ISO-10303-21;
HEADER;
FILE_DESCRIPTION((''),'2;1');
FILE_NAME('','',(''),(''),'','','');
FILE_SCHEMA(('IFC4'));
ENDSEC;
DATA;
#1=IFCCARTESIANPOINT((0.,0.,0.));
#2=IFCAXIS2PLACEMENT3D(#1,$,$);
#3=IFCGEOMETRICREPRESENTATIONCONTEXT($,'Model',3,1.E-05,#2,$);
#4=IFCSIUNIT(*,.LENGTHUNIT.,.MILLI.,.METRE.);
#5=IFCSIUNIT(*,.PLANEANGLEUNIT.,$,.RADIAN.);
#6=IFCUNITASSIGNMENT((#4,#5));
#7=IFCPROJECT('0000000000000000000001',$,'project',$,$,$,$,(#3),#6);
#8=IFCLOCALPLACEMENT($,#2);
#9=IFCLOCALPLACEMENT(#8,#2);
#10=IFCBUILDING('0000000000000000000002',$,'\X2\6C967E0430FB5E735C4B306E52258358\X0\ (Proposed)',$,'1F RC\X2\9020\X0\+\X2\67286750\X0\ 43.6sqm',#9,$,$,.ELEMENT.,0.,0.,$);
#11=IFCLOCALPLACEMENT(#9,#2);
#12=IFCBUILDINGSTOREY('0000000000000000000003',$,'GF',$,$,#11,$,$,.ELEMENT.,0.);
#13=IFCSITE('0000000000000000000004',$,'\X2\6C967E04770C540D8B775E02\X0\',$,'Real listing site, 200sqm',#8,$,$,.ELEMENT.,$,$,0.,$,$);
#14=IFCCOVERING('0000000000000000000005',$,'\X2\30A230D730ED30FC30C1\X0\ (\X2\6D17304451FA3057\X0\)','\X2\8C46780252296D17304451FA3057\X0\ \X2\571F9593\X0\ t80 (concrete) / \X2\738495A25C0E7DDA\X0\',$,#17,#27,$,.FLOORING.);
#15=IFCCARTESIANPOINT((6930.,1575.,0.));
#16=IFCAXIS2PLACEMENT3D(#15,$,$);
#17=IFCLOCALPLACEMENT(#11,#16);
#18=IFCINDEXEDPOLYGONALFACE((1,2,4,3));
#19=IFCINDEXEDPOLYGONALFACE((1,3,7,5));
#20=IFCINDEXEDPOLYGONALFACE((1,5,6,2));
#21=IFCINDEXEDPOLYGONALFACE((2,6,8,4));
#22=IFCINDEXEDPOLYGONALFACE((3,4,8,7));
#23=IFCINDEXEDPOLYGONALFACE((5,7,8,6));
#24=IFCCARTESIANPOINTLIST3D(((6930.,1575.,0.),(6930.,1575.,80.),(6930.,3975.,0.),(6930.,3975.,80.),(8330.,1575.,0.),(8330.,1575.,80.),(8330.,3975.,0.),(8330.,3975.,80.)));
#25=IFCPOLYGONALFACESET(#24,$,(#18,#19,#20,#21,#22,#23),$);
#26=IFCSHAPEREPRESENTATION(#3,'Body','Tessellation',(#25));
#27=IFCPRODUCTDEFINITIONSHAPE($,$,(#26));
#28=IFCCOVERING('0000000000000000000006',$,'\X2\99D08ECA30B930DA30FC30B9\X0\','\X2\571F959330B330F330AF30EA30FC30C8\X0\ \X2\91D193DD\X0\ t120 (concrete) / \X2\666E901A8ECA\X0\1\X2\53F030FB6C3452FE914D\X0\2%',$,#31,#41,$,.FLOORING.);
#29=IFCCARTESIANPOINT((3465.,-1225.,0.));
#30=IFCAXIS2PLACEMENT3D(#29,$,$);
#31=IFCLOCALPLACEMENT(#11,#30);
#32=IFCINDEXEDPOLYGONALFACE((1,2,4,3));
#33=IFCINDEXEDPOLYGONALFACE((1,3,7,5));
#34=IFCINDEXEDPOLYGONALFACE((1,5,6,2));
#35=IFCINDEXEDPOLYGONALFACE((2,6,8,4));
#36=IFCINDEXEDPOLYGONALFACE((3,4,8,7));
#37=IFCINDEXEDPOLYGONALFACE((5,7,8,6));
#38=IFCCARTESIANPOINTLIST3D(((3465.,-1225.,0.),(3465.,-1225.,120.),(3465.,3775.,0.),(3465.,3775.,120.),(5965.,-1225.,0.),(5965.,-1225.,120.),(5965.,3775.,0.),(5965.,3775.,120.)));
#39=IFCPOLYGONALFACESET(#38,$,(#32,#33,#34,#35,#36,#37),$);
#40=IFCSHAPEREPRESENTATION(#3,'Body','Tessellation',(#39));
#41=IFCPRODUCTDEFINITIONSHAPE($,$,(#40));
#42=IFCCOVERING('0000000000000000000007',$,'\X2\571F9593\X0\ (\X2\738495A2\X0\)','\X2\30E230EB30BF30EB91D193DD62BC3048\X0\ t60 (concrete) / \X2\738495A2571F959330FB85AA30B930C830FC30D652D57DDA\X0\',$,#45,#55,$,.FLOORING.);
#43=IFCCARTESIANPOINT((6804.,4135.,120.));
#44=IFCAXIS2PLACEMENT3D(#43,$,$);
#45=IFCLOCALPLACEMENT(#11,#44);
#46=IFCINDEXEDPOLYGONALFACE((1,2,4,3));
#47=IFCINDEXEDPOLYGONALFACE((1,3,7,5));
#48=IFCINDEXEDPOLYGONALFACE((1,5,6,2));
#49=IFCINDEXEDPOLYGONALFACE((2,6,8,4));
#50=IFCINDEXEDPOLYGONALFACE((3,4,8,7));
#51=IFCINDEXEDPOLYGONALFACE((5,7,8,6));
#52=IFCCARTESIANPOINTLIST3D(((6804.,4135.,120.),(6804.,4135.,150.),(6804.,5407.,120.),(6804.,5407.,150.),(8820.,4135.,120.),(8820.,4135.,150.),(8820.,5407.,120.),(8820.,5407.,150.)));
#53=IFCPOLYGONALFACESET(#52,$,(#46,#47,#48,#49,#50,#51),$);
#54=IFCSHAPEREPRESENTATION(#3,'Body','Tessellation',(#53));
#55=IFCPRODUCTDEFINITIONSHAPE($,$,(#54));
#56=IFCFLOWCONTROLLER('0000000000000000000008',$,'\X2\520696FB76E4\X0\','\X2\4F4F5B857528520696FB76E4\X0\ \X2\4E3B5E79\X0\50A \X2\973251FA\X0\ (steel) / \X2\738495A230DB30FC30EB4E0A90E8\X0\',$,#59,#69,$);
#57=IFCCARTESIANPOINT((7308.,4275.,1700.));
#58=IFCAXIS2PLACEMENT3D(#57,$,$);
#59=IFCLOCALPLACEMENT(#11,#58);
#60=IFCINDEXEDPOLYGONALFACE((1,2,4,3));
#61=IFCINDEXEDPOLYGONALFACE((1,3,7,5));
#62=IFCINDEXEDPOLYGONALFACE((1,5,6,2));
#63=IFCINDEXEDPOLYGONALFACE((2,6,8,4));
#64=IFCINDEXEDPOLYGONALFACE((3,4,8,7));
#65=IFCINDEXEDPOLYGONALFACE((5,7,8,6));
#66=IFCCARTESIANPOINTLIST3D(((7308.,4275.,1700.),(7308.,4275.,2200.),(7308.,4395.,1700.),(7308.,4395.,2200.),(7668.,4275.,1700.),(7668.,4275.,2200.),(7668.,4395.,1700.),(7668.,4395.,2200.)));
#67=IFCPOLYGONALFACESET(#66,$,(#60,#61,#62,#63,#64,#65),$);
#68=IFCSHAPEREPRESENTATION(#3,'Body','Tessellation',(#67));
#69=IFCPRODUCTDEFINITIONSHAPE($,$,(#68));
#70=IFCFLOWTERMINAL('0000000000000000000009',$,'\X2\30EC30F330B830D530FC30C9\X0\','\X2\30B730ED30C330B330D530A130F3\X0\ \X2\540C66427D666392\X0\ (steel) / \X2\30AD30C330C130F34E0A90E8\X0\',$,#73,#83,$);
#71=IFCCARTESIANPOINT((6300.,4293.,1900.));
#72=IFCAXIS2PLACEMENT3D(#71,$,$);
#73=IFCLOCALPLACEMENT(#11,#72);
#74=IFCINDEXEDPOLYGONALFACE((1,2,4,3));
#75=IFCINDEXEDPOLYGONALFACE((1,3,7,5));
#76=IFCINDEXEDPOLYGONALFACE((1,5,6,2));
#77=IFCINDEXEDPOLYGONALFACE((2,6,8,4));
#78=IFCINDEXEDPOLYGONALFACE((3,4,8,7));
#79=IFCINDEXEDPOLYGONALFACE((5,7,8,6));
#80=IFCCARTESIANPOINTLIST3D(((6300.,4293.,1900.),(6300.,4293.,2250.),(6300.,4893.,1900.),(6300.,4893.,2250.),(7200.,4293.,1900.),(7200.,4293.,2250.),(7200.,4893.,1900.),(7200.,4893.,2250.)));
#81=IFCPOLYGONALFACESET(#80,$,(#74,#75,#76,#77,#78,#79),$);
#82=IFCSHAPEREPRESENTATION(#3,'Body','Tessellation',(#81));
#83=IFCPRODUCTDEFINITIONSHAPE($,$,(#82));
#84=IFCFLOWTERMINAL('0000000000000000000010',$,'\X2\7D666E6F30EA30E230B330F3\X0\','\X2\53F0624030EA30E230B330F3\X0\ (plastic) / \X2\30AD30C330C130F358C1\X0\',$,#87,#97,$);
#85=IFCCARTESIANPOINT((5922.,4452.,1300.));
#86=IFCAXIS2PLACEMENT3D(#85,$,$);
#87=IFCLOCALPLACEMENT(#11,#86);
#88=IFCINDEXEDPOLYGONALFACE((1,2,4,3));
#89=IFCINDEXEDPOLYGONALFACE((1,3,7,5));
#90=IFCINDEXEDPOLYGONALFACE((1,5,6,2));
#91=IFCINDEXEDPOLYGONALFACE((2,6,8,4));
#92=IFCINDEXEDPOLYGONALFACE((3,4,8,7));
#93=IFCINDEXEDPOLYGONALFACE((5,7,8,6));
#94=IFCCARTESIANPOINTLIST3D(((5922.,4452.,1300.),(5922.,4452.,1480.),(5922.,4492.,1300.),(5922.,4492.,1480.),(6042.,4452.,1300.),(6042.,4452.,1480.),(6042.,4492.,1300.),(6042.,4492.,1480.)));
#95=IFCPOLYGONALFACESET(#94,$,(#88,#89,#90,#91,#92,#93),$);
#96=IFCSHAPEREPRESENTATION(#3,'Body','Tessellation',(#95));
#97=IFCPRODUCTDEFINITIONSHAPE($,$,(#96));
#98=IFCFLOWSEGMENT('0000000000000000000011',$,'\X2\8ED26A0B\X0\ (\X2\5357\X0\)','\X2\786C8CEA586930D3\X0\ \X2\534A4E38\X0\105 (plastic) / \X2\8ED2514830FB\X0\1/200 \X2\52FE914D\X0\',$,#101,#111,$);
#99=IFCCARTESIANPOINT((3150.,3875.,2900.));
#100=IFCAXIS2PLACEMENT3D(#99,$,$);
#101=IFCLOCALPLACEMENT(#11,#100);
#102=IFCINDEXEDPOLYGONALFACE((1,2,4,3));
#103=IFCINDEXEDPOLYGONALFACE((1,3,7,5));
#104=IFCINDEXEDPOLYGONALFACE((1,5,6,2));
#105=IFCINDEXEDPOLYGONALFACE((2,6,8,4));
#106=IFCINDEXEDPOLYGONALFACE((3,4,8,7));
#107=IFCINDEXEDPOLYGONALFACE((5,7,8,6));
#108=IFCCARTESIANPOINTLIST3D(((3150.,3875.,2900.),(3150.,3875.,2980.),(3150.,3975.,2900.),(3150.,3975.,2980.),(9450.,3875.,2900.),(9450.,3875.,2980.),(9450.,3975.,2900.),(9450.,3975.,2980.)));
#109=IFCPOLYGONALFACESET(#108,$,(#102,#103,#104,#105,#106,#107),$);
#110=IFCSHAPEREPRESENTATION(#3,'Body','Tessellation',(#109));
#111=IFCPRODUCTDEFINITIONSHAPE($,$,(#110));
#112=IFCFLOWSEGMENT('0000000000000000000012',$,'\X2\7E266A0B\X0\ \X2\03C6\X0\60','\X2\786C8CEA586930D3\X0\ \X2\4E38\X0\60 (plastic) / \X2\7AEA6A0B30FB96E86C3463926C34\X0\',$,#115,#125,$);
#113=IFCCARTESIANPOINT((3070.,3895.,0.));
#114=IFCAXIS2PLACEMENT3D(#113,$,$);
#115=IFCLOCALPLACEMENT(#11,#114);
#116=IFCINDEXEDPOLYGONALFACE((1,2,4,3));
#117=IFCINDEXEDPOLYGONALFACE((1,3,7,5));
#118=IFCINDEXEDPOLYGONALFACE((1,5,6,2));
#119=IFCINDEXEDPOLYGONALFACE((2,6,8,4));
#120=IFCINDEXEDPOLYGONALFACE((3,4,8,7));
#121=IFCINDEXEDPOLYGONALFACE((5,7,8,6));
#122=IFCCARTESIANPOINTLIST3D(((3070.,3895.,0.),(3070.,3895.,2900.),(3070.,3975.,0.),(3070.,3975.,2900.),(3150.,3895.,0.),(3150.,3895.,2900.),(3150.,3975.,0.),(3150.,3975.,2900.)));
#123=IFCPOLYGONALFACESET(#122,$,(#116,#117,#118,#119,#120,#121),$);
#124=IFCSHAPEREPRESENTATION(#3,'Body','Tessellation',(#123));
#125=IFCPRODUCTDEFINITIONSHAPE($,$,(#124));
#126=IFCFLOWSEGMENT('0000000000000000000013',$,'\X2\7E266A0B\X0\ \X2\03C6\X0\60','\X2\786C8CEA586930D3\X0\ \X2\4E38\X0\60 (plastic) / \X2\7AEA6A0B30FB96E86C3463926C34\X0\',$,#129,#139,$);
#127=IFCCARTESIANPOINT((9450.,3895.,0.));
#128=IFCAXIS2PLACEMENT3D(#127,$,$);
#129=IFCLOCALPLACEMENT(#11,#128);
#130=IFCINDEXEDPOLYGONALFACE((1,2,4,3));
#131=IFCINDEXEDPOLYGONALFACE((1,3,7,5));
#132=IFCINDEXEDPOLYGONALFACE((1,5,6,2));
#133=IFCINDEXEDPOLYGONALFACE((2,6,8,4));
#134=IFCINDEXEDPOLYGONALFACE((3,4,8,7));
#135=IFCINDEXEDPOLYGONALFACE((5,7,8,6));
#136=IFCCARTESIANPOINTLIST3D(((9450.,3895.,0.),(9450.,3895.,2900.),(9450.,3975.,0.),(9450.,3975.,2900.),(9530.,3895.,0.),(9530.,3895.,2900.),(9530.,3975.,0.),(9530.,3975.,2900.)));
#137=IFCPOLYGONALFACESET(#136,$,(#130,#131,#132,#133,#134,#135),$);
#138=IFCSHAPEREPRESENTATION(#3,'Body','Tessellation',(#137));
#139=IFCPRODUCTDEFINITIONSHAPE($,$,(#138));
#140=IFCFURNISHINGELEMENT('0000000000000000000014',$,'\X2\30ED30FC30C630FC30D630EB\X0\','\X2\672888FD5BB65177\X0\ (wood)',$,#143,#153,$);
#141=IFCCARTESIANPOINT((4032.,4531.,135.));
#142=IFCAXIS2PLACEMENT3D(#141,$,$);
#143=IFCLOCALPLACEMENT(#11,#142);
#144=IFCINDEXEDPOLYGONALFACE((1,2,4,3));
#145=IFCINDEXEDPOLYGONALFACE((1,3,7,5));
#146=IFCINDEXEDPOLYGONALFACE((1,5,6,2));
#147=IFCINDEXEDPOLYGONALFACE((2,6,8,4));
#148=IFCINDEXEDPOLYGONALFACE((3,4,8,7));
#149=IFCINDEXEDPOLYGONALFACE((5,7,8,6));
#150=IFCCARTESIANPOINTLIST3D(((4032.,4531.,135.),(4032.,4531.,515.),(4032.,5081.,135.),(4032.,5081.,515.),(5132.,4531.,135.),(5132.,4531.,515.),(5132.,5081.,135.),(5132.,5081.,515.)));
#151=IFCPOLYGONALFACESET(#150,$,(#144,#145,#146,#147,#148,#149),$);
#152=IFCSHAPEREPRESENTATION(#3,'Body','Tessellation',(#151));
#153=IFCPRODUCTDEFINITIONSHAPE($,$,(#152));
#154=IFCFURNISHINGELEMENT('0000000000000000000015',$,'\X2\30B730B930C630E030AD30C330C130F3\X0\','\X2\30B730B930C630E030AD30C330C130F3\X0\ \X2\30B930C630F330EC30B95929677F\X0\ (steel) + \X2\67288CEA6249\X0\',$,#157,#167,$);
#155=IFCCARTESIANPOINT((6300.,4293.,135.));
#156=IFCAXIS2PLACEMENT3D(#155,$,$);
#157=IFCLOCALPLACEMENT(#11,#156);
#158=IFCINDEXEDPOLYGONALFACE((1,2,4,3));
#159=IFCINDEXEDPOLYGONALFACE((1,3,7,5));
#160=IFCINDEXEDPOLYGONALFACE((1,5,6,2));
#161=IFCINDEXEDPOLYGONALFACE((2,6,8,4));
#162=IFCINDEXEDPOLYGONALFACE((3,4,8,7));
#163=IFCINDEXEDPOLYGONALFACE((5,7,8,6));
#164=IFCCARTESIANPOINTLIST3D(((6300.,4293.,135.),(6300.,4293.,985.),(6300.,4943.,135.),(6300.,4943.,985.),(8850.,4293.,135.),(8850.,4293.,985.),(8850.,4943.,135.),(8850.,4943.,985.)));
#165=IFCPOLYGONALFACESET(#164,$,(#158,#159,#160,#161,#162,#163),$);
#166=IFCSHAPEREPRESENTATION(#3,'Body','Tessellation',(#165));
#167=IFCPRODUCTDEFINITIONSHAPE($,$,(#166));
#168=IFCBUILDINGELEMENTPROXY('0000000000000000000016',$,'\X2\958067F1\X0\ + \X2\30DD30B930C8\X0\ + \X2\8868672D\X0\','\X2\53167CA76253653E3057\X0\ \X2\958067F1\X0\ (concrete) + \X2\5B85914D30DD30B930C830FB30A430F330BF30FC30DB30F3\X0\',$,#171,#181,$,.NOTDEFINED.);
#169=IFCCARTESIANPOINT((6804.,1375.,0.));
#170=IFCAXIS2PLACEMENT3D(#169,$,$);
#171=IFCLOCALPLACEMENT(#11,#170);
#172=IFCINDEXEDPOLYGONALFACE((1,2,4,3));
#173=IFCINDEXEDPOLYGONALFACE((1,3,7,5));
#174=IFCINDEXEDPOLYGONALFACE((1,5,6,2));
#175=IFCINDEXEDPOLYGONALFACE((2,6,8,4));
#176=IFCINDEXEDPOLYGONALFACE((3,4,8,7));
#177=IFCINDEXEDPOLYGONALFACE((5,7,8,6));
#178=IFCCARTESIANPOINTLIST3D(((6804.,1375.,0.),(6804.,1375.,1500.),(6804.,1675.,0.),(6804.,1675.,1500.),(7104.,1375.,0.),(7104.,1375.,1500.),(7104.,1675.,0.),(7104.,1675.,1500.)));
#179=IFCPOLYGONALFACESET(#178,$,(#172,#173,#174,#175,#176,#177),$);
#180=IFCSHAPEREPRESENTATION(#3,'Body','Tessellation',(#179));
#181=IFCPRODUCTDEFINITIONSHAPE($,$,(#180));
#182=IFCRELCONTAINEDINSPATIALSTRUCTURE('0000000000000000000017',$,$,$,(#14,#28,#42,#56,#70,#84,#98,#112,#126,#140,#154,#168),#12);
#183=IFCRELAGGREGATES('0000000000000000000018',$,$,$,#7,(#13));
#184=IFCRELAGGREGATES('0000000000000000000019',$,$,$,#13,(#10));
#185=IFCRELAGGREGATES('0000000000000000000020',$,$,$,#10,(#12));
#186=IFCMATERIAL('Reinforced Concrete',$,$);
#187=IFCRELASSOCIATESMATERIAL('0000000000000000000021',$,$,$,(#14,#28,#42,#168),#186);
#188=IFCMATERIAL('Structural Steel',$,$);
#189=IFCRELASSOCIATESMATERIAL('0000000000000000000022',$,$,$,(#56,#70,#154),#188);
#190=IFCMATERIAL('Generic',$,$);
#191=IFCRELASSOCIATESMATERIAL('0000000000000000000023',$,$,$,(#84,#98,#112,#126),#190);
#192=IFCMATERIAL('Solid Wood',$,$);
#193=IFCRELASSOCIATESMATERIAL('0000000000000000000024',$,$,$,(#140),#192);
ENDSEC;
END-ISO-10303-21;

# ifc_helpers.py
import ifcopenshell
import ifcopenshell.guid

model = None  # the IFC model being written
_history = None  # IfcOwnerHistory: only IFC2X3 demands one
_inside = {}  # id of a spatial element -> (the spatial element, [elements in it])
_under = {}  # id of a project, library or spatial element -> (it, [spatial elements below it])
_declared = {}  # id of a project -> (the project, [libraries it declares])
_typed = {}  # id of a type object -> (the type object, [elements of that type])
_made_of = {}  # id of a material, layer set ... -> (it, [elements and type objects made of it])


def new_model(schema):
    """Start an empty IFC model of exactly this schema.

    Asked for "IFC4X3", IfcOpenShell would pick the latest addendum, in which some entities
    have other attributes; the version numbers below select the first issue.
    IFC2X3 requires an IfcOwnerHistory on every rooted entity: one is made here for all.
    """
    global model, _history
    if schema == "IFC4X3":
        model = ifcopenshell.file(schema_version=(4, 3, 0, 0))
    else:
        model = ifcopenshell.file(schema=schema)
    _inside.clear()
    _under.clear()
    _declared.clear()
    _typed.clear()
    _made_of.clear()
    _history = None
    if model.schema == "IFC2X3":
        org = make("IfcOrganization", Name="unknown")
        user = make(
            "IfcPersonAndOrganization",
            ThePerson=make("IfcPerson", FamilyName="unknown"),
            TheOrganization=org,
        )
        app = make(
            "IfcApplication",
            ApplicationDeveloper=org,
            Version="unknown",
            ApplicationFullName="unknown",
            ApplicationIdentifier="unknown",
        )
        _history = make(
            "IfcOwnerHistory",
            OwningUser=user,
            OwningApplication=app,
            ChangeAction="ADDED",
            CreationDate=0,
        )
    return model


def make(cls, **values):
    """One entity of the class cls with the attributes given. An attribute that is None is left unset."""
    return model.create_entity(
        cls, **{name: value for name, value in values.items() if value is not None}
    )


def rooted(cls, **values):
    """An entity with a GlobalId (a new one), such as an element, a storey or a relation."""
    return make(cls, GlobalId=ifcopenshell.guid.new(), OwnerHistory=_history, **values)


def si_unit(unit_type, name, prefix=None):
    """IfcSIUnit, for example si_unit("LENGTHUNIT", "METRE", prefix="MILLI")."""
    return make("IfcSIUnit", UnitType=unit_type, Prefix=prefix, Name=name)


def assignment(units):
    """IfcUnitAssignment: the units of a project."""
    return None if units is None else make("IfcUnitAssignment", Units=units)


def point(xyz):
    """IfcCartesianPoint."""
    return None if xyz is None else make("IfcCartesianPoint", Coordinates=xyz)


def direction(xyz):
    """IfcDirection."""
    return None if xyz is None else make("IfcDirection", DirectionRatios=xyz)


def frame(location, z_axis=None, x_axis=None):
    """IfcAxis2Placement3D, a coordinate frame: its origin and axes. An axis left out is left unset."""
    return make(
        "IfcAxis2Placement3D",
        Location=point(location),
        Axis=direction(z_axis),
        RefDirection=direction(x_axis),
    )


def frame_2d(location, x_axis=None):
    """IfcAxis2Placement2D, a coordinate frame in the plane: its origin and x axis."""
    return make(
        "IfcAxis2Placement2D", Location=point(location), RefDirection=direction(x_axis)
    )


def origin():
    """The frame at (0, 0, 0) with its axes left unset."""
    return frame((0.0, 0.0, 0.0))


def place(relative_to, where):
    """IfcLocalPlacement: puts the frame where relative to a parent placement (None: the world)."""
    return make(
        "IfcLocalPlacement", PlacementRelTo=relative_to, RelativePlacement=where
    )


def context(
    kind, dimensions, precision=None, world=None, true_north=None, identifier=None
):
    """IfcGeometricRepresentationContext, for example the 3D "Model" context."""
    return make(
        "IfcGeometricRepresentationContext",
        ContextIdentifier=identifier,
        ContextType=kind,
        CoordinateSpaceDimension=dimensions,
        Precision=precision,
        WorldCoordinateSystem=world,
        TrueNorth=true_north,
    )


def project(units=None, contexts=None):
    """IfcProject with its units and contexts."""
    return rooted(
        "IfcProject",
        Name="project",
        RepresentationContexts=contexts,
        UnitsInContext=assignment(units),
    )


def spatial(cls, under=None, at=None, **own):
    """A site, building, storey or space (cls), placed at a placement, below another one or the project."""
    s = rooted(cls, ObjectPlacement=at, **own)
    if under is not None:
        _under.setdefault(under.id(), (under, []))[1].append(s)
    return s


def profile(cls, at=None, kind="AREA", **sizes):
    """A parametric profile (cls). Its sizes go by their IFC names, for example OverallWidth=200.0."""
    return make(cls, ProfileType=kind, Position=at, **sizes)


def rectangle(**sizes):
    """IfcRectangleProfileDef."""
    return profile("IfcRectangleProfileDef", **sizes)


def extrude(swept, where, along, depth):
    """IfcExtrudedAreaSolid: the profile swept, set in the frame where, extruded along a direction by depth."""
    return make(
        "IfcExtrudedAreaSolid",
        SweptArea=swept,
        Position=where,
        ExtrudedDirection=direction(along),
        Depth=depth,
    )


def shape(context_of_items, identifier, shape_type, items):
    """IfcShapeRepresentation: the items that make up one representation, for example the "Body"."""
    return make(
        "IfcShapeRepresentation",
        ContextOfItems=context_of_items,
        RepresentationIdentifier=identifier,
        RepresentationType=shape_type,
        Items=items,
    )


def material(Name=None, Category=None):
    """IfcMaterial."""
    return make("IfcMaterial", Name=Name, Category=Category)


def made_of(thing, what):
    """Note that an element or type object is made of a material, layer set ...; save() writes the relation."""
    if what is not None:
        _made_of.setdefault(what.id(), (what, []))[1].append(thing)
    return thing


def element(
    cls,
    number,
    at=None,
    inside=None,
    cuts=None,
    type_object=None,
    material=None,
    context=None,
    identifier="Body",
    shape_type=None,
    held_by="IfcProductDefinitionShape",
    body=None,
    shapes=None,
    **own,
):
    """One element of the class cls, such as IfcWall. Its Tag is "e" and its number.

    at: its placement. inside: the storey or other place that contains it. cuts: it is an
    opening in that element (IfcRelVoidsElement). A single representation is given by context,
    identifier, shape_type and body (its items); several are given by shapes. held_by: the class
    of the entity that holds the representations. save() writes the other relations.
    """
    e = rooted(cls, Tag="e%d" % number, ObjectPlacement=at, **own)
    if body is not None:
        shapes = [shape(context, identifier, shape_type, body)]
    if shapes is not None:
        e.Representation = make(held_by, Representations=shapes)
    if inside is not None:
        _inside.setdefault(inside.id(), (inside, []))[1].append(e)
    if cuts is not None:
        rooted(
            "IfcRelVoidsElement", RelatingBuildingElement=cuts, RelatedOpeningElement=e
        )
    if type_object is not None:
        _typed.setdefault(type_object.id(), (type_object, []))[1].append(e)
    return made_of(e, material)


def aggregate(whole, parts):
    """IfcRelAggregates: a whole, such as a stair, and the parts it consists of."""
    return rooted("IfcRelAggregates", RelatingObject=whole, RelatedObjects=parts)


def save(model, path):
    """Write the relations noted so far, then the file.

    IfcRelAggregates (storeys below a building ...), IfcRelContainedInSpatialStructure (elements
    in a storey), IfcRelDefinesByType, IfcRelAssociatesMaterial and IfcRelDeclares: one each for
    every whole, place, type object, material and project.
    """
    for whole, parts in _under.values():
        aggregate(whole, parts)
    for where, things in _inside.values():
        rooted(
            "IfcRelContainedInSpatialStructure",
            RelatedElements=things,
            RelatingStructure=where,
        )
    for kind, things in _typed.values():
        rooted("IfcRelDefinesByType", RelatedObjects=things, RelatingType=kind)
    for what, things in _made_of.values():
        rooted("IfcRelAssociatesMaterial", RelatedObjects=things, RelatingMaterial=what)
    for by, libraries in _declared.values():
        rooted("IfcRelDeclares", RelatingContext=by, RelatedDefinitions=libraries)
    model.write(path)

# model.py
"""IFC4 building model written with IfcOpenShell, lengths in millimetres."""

from ifc_helpers import new_model, si_unit, frame, frame_2d, origin, place, context, project, spatial, rectangle, extrude, material, element, save


model = new_model("IFC4")

# Units and contexts
model_context = context("Model", 3, precision=1e-05, world=origin())
ifc_project = project(units=[si_unit("LENGTHUNIT", "METRE", prefix="MILLI"), si_unit("PLANEANGLEUNIT", "RADIAN")], contexts=[model_context])

# Site, building, storey
site_placement = place(None, origin())
site = spatial("IfcSite", under=ifc_project, at=site_placement, Name="沖縄県名護市", ObjectType="Real listing site, 200sqm", CompositionType="ELEMENT", RefElevation=0.0)
building_placement = place(site_placement, origin())
building = spatial("IfcBuilding", under=site, at=building_placement, Name="沖縄・平屋の別荘 (Proposed)", ObjectType="1F RC造+木材 43.6sqm", CompositionType="ELEMENT", ElevationOfRefHeight=0.0, ElevationOfTerrain=0.0)
storey_placement = place(building_placement, origin())
storey = spatial("IfcBuildingStorey", under=building, at=storey_placement, Name="GF", CompositionType="ELEMENT", Elevation=0.0)

# Shared definitions
ifc_material_1 = material(Name="Solid Wood")

# Shared definitions
ifc_material_2 = material(Name="Reinforced Concrete")

# Shared definitions
ifc_material_3 = material(Name="Structural Steel")

# Coverings
ifc_material_4 = material(Name="Generic")
covering_1_placement = place(storey_placement, frame((6930.0, 1575.0, 0.0)))
element("IfcCovering", 1, at=covering_1_placement, inside=storey, material=ifc_material_2, Name="アプローチ (洗い出し)", Description="豆砂利洗い出し 土間 t80 (concrete) / 玄関導線", PredefinedType="FLOORING", context=model_context, shape_type="SweptSolid", body=[
    extrude(rectangle(XDim=1400.0, YDim=2400.0, at=frame_2d((700.0, 1200.0))), frame((6930.0, 1575.0, 0.0)), (0.0, 0.0, 1.0), 80.0),
])
covering_2_placement = place(storey_placement, frame((3465.0, -1225.0, 0.0)))
element("IfcCovering", 2, at=covering_2_placement, inside=storey, material=ifc_material_2, Name="駐車スペース", Description="土間コンクリート 金鏝 t120 (concrete) / 普通車1台・水勾配2%", PredefinedType="FLOORING", context=model_context, shape_type="SweptSolid", body=[
    extrude(rectangle(XDim=2500.0, YDim=5000.0, at=frame_2d((1250.0, 2500.0))), frame((3465.0, -1225.0, 0.0)), (0.0, 0.0, 1.0), 120.0),
])
covering_3_placement = place(storey_placement, frame((6804.0, 4135.0, 120.0)))
element("IfcCovering", 3, at=covering_3_placement, inside=storey, material=ifc_material_2, Name="土間 (玄関)", Description="モルタル金鏝押え t60 (concrete) / 玄関土間・薪ストーブ動線", PredefinedType="FLOORING", context=model_context, shape_type="SweptSolid", body=[
    extrude(rectangle(XDim=2016.0, YDim=1272.0, at=frame_2d((1008.0, 636.0))), frame((6804.0, 4135.0, 120.0)), (0.0, 0.0, 1.0), 30.0),
])

# Flow controller
flow_controller_placement = place(storey_placement, frame((7308.0, 4275.0, 1700.0)))
element("IfcFlowController", 4, at=flow_controller_placement, inside=storey, material=ifc_material_3, Name="分電盤", Description="住宅用分電盤 主幹50A 露出 (steel) / 玄関ホール上部", context=model_context, shape_type="SweptSolid", body=[
    extrude(rectangle(XDim=360.0, YDim=120.0, at=frame_2d((180.0, 60.0))), frame((7308.0, 4275.0, 1700.0)), (0.0, 0.0, 1.0), 500.0),
])

# Flow terminals
flow_terminal_1_placement = place(storey_placement, frame((6300.0, 4293.0, 1900.0)))
element("IfcFlowTerminal", 5, at=flow_terminal_1_placement, inside=storey, material=ifc_material_3, Name="レンジフード", Description="シロッコファン 同時給排 (steel) / キッチン上部", context=model_context, shape_type="SweptSolid", body=[
    extrude(rectangle(XDim=900.0, YDim=600.0, at=frame_2d((450.0, 300.0))), frame((6300.0, 4293.0, 1900.0)), (0.0, 0.0, 1.0), 350.0),
])
flow_terminal_2_placement = place(storey_placement, frame((5922.0, 4452.0, 1300.0)))
element("IfcFlowTerminal", 6, at=flow_terminal_2_placement, inside=storey, material=ifc_material_4, Name="給湯リモコン", Description="台所リモコン (plastic) / キッチン壁", context=model_context, shape_type="SweptSolid", body=[
    extrude(rectangle(XDim=120.0, YDim=40.0, at=frame_2d((60.0, 20.0))), frame((5922.0, 4452.0, 1300.0)), (0.0, 0.0, 1.0), 180.0),
])

# Flow segments
flow_segment_1_placement = place(storey_placement, frame((3150.0, 3875.0, 2900.0)))
element("IfcFlowSegment", 7, at=flow_segment_1_placement, inside=storey, material=ifc_material_4, Name="軒樋 (南)", Description="硬質塩ビ 半丸105 (plastic) / 軒先・1/200 勾配", context=model_context, shape_type="SweptSolid", body=[
    extrude(rectangle(XDim=6300.0, YDim=100.0, at=frame_2d((3150.0, 50.0))), frame((3150.0, 3875.0, 2900.0)), (0.0, 0.0, 1.0), 80.0),
])
flow_segment_2_placement = place(storey_placement, frame((3070.0, 3895.0, 0.0)))
element("IfcFlowSegment", 8, at=flow_segment_2_placement, inside=storey, material=ifc_material_4, Name="縦樋 φ60", Description="硬質塩ビ 丸60 (plastic) / 竪樋・雨水排水", context=model_context, shape_type="SweptSolid", body=[
    extrude(rectangle(XDim=80.0, YDim=80.0, at=frame_2d((40.0, 40.0))), frame((3070.0, 3895.0, 0.0)), (0.0, 0.0, 1.0), 2900.0),
])
flow_segment_3_placement = place(storey_placement, frame((9450.0, 3895.0, 0.0)))
element("IfcFlowSegment", 9, at=flow_segment_3_placement, inside=storey, material=ifc_material_4, Name="縦樋 φ60", Description="硬質塩ビ 丸60 (plastic) / 竪樋・雨水排水", context=model_context, shape_type="SweptSolid", body=[
    extrude(rectangle(XDim=80.0, YDim=80.0, at=frame_2d((40.0, 40.0))), frame((9450.0, 3895.0, 0.0)), (0.0, 0.0, 1.0), 2900.0),
])

# Furnishing elements
furnishing_1_placement = place(storey_placement, frame((4032.0, 4531.0, 135.0)))
element("IfcFurnishingElement", 10, at=furnishing_1_placement, inside=storey, material=ifc_material_1, Name="ローテーブル", Description="木製家具 (wood)", context=model_context, shape_type="SweptSolid", body=[
    extrude(rectangle(XDim=1100.0, YDim=550.0, at=frame_2d((550.0, 275.0))), frame((4032.0, 4531.0, 135.0)), (0.0, 0.0, 1.0), 380.0),
])
furnishing_2_placement = place(storey_placement, frame((6300.0, 4293.0, 135.0)))
element("IfcFurnishingElement", 11, at=furnishing_2_placement, inside=storey, material=ifc_material_3, Name="システムキッチン", Description="システムキッチン ステンレス天板 (steel) + 木質扉", context=model_context, shape_type="SweptSolid", body=[
    extrude(rectangle(XDim=2550.0, YDim=650.0, at=frame_2d((1275.0, 325.0))), frame((6300.0, 4293.0, 135.0)), (0.0, 0.0, 1.0), 850.0),
])

# Building element proxy
proxy_placement = place(storey_placement, frame((6804.0, 1375.0, 0.0)))
element("IfcBuildingElementProxy", 12, at=proxy_placement, inside=storey, material=ifc_material_2, Name="門柱 + ポスト + 表札", Description="化粧打放し 門柱 (concrete) + 宅配ポスト・インターホン", PredefinedType="NOTDEFINED", context=model_context, shape_type="SweptSolid", body=[
    extrude(rectangle(XDim=300.0, YDim=300.0, at=frame_2d((150.0, 150.0))), frame((6804.0, 1375.0, 0.0)), (0.0, 0.0, 1.0), 1500.0),
])

save(model, "model.ifc")
